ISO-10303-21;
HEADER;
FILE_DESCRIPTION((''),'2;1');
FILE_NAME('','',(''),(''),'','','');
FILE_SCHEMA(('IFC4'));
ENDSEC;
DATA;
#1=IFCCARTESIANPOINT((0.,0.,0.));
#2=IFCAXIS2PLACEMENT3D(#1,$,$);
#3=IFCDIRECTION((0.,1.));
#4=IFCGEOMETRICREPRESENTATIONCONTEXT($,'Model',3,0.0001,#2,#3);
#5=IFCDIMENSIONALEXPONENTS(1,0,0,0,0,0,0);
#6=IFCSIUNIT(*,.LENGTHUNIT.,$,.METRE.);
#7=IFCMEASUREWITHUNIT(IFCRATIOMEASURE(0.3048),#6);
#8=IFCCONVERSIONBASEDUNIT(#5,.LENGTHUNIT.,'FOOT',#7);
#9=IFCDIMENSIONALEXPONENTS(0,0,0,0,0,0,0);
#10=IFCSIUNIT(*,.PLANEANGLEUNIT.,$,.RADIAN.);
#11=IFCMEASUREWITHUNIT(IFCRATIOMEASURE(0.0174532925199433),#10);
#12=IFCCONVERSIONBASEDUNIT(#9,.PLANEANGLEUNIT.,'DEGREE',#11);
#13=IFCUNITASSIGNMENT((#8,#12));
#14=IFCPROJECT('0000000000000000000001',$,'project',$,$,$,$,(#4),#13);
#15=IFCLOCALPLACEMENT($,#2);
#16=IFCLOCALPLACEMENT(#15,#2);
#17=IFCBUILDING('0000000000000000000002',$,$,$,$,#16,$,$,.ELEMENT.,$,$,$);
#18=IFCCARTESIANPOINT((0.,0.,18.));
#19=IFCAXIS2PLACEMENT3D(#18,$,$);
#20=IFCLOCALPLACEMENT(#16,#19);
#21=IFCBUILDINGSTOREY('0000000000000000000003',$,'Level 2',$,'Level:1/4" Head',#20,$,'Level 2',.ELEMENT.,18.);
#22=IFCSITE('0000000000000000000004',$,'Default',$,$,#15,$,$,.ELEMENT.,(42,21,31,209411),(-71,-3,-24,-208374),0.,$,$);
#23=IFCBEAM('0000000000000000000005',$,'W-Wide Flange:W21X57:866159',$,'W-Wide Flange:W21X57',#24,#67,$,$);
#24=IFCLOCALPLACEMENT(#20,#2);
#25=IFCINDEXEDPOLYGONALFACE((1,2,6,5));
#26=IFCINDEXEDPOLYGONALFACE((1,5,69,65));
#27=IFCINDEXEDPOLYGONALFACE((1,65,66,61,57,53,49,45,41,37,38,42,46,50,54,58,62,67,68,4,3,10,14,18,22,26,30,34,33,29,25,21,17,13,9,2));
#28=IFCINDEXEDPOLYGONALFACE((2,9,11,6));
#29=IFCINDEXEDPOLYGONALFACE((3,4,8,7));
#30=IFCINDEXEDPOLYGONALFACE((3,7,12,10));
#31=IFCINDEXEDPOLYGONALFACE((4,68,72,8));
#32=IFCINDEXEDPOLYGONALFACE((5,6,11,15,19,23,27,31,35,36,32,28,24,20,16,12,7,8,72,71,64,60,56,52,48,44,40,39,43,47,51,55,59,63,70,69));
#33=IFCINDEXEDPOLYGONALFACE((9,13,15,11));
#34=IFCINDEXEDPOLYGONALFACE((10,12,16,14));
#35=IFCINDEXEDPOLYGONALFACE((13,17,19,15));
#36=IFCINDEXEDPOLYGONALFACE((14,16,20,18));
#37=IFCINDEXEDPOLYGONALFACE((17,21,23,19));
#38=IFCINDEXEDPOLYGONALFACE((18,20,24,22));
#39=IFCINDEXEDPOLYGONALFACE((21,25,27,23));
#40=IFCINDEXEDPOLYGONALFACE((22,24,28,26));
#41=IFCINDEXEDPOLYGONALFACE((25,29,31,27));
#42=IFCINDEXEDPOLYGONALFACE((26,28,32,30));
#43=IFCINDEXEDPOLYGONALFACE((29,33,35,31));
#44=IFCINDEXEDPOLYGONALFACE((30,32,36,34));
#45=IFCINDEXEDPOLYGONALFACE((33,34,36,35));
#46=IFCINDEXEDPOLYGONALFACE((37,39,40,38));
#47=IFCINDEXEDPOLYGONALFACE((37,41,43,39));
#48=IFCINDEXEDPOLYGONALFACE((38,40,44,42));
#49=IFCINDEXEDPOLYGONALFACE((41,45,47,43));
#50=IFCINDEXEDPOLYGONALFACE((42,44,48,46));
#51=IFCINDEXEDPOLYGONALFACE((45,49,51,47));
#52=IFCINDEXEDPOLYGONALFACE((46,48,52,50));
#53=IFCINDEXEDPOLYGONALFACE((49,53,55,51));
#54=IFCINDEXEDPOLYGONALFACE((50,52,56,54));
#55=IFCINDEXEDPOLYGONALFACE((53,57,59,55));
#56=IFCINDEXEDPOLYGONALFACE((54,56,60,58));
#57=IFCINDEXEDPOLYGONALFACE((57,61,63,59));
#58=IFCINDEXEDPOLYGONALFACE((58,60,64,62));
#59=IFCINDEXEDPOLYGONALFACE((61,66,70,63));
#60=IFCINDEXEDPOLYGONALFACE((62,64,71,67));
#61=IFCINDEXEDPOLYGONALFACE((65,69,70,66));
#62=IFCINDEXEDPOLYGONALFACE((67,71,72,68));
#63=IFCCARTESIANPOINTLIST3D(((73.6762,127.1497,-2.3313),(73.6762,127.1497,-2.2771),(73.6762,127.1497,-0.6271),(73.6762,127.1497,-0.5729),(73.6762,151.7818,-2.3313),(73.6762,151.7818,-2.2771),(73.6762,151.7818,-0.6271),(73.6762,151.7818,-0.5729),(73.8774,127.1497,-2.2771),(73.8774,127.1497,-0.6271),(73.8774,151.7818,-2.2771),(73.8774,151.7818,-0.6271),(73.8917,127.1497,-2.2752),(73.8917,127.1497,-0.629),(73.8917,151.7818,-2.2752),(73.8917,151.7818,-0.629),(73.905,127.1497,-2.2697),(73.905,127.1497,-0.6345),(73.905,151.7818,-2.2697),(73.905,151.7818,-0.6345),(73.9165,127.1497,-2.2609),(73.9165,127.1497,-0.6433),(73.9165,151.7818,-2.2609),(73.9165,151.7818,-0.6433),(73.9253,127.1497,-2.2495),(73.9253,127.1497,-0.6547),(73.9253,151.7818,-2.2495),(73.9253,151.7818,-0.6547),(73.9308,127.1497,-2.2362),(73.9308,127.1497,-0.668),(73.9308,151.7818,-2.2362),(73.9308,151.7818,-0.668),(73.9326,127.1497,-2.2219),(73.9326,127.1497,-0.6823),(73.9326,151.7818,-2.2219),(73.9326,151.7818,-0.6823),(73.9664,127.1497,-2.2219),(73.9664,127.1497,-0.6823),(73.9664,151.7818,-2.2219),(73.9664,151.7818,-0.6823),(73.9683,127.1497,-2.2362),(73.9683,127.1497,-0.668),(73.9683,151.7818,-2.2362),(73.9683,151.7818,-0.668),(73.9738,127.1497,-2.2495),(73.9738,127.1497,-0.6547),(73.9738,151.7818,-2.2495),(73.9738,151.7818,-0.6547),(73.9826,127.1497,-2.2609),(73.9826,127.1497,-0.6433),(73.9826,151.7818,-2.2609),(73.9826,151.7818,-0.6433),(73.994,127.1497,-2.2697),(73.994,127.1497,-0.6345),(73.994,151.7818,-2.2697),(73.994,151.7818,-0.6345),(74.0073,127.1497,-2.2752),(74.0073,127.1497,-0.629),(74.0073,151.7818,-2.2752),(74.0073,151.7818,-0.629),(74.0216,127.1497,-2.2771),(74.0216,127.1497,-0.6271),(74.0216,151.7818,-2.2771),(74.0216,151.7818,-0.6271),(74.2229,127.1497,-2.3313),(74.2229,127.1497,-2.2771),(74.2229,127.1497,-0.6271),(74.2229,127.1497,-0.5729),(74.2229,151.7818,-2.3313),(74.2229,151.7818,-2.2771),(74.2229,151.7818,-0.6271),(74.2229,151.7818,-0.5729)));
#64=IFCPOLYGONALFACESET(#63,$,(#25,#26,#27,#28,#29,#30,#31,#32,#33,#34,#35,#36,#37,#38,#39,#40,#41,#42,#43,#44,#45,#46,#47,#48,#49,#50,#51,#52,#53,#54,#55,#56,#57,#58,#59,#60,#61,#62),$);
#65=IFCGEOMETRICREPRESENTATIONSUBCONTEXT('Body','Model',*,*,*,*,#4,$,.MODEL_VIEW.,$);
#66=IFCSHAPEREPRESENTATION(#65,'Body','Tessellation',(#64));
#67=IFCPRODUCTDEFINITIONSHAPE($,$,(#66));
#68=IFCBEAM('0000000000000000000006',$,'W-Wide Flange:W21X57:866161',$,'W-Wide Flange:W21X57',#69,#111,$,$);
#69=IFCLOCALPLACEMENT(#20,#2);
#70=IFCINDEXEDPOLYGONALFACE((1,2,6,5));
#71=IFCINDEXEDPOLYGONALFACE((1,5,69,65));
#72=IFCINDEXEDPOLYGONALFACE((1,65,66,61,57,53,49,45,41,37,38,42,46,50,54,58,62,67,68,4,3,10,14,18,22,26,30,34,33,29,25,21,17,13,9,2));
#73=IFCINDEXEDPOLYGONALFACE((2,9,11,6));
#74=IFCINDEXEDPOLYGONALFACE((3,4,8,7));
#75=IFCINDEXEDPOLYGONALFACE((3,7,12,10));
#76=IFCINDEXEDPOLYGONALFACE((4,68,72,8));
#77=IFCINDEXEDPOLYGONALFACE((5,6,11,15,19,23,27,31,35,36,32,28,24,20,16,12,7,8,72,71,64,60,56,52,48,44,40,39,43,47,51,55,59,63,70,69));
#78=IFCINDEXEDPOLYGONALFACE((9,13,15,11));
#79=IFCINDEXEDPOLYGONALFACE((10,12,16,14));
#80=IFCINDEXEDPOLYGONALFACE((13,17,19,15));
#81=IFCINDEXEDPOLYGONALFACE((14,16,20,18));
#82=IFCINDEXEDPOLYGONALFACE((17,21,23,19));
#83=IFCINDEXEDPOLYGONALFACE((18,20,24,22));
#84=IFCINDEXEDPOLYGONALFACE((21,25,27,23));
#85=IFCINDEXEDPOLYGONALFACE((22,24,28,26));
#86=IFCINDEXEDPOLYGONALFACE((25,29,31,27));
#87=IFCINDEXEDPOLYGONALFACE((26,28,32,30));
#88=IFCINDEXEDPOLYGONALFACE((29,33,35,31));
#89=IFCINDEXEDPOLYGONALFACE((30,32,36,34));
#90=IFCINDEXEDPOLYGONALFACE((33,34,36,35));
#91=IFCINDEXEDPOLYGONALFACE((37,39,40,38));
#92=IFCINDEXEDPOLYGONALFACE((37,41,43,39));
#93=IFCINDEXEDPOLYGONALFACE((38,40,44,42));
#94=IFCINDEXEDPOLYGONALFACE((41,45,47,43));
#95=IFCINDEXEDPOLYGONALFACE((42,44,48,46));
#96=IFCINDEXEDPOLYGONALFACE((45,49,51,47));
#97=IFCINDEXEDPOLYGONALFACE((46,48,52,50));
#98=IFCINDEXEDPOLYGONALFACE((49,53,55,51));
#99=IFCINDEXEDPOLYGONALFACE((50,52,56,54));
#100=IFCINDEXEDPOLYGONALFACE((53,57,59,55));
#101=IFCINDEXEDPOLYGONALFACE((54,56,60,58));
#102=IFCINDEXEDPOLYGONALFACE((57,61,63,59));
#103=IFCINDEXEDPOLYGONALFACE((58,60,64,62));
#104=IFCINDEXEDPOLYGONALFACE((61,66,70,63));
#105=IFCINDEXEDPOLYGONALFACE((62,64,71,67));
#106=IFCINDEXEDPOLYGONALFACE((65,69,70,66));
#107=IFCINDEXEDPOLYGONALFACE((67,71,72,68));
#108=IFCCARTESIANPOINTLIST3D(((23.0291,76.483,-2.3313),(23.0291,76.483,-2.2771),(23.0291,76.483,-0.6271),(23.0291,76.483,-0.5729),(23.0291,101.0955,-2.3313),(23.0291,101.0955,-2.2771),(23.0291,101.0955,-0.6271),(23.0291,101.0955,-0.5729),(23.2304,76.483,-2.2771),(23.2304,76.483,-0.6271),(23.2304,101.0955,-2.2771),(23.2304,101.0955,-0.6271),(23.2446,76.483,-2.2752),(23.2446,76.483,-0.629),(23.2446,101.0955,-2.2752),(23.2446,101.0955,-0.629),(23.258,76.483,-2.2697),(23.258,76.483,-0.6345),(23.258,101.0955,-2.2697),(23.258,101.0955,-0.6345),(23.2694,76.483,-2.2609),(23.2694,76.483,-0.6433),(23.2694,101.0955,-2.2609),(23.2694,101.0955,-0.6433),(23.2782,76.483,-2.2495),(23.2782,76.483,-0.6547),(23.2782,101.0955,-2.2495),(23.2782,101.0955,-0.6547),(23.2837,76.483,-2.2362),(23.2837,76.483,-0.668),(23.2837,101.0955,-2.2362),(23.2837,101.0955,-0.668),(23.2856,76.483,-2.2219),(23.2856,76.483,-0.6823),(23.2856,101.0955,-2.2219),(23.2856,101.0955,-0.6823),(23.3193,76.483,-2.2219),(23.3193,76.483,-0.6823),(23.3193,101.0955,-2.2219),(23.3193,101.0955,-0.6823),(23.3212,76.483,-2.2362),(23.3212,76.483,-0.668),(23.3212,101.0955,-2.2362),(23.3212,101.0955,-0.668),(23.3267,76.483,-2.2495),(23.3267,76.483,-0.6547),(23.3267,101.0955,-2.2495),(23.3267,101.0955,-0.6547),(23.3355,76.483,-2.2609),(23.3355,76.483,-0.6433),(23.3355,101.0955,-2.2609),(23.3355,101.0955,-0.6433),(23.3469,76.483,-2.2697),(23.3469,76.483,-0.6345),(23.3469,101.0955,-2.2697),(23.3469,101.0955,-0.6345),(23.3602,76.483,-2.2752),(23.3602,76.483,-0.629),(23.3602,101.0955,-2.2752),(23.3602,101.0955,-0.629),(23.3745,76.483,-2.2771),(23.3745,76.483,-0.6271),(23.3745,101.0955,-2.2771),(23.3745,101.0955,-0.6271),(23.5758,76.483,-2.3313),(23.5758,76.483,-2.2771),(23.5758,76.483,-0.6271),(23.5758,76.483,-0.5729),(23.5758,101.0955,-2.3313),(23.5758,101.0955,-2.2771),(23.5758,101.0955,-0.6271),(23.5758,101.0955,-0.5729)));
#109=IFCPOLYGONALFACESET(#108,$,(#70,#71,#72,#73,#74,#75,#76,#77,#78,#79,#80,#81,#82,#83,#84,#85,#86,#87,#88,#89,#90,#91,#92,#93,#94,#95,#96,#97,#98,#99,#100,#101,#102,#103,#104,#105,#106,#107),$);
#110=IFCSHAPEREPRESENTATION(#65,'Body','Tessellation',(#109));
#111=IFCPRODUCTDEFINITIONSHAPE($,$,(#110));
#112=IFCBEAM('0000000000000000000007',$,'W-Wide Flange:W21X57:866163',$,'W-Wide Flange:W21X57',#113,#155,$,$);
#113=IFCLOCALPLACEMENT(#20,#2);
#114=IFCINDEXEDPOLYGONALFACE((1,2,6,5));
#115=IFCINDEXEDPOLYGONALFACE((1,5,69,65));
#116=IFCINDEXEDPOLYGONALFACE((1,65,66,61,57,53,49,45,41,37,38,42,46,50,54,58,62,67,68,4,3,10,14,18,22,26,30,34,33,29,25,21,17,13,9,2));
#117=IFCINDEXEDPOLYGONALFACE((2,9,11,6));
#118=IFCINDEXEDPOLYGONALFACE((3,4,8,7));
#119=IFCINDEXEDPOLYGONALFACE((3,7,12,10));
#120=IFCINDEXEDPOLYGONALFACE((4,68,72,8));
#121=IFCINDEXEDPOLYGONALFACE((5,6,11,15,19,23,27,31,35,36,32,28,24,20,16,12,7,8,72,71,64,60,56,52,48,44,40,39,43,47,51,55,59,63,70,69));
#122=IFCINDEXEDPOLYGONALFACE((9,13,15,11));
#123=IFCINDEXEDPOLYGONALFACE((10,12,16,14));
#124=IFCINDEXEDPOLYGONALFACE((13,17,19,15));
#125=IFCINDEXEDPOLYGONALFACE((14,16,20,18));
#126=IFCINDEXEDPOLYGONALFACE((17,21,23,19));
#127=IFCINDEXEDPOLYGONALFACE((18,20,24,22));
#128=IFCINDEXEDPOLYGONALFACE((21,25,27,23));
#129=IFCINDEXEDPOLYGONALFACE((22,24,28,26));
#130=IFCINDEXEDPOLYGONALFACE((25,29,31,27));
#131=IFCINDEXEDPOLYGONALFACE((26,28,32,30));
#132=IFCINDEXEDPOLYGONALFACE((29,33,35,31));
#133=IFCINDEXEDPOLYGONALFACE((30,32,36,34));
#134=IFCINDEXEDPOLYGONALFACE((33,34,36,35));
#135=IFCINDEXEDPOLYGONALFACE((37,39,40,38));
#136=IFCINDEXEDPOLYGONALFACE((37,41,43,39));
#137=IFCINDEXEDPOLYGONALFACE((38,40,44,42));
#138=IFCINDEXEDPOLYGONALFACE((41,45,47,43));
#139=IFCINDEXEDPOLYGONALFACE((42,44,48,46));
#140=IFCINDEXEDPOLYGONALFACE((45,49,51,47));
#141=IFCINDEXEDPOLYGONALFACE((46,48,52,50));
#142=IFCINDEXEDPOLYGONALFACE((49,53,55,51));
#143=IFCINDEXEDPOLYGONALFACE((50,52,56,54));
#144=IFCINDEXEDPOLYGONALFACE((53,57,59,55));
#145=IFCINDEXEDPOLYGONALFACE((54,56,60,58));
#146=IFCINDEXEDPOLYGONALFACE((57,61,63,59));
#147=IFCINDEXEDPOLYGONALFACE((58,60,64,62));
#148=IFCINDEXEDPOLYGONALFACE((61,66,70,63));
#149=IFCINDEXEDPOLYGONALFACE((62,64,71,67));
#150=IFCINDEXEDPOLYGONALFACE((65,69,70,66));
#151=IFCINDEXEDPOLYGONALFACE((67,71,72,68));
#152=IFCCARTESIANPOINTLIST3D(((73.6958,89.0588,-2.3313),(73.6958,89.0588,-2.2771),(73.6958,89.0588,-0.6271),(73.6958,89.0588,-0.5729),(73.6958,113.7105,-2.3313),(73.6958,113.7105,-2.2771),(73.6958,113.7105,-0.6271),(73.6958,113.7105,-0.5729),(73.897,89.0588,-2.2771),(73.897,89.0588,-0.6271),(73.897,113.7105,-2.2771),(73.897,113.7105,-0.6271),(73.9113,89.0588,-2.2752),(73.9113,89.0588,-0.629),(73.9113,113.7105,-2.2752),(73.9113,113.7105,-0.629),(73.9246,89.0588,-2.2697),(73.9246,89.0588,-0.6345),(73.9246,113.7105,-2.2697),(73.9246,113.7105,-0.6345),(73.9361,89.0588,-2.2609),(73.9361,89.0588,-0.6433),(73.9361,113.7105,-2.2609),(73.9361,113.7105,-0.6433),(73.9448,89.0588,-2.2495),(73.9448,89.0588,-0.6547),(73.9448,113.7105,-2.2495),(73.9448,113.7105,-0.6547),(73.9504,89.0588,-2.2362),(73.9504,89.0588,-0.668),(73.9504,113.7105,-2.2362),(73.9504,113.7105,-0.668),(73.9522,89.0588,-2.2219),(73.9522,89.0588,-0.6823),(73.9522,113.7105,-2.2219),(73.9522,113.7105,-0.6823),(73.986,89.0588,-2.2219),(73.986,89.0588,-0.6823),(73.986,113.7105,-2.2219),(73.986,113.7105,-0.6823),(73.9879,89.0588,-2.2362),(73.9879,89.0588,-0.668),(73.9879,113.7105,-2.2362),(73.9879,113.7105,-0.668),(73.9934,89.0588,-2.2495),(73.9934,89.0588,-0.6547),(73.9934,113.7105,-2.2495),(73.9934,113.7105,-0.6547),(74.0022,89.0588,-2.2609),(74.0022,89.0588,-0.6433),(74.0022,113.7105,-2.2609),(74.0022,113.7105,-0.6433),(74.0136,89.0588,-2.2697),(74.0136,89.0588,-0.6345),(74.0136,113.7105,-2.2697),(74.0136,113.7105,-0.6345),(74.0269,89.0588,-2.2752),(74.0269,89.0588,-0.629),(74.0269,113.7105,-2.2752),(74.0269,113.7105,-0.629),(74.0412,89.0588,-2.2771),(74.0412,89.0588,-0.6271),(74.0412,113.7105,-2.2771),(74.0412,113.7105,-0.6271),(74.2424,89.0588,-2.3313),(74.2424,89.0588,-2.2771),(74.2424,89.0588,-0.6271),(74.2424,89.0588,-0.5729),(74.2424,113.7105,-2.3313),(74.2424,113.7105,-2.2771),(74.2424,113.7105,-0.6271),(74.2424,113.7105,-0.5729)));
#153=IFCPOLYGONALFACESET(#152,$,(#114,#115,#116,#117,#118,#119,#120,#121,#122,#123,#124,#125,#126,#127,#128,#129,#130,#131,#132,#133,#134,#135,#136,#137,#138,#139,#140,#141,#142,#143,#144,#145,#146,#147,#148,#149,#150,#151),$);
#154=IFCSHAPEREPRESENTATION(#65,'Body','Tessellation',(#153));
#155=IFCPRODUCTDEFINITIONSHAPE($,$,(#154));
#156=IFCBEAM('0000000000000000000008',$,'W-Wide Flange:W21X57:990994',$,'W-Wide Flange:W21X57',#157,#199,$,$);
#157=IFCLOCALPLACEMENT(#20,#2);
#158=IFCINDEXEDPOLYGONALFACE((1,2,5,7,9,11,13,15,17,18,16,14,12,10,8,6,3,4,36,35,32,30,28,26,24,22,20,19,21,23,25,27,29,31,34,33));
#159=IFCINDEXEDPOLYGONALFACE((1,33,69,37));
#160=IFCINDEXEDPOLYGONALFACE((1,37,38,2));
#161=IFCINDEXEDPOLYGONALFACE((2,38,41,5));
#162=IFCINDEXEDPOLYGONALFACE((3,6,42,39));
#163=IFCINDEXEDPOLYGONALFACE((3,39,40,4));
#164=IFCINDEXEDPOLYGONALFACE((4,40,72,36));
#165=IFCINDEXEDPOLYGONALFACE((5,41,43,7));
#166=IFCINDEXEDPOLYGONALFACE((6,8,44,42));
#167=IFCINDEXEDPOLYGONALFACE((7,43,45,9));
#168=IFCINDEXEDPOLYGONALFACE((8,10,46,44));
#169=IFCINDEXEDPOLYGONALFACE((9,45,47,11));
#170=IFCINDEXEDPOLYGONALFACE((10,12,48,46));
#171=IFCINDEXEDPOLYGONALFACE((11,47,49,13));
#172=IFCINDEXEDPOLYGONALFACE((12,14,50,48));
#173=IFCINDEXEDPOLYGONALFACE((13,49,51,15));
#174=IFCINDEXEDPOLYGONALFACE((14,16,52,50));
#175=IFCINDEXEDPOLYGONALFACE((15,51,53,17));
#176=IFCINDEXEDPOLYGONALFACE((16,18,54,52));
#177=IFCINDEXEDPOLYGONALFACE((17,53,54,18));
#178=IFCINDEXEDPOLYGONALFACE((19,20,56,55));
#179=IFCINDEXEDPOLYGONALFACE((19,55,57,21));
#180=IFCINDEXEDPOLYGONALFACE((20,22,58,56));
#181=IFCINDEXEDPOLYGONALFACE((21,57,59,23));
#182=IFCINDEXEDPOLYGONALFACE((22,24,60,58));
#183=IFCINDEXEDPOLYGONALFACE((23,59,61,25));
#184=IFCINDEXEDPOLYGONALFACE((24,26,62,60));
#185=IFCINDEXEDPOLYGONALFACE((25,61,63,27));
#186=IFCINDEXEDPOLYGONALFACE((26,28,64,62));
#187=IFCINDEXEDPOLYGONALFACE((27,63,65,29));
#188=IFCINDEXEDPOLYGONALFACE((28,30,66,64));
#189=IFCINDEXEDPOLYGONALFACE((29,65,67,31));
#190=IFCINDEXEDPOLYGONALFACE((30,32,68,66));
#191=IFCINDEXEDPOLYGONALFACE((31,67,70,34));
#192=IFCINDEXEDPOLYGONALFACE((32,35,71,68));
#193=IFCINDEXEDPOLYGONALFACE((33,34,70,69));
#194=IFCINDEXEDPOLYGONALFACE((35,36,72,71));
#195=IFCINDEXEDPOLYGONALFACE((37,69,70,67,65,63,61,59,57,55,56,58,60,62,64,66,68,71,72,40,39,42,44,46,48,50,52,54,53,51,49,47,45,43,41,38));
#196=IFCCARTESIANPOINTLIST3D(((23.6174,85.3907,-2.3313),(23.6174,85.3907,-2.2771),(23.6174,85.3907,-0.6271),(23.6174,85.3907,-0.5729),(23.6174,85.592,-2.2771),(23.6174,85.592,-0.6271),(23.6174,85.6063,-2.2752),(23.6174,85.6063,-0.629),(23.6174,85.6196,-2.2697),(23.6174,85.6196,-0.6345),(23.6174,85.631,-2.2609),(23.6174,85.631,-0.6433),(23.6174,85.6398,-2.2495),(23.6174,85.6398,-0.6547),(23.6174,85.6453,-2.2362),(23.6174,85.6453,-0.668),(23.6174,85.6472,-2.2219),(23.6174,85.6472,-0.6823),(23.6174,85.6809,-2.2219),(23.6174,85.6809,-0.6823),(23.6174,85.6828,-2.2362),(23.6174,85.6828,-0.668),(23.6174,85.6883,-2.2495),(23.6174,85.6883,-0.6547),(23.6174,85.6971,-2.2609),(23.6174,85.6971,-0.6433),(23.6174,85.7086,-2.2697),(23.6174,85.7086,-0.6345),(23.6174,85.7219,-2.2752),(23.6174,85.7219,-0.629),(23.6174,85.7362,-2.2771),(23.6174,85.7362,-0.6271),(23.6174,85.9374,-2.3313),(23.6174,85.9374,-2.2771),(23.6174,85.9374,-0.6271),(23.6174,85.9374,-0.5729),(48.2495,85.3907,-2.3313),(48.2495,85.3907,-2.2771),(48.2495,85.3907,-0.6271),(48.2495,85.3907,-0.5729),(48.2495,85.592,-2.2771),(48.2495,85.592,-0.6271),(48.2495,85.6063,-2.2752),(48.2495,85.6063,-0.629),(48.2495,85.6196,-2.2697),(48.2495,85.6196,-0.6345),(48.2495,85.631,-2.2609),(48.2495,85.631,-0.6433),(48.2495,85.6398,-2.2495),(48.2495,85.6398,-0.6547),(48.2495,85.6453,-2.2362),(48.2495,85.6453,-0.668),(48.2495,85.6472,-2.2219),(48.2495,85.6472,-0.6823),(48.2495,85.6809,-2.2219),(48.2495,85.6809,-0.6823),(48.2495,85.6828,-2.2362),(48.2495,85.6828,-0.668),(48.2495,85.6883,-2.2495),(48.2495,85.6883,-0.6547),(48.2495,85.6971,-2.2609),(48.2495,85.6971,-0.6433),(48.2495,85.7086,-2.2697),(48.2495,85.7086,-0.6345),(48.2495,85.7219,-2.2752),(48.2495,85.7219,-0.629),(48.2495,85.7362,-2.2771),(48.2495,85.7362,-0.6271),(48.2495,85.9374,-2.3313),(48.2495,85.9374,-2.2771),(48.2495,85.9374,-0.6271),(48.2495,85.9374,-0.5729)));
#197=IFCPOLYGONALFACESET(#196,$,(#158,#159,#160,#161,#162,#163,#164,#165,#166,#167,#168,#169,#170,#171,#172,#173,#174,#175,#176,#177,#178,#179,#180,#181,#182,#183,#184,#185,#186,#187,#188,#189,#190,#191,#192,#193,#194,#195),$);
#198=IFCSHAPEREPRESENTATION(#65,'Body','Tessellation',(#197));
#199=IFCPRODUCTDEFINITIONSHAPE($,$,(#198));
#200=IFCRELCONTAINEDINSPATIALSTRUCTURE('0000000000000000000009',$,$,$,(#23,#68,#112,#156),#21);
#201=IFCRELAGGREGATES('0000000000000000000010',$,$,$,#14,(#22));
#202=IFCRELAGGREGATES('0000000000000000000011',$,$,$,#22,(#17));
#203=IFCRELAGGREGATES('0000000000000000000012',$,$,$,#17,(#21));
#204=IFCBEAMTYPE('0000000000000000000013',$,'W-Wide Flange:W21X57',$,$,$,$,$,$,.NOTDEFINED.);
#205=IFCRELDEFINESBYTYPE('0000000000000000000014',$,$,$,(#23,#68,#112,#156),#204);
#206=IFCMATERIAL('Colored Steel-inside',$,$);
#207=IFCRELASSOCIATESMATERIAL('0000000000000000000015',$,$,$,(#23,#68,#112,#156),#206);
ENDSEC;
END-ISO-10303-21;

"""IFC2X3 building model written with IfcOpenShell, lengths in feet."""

from ifc_helpers import new_model, entity, si_unit, converted_unit, direction, frame, frame_2d, origin, place, context, subcontext, project, spatial, i_section, extrude, material, type_object, element, save


model = new_model("IFC2X3")

# Units and contexts
model_context = context("Model", 3, precision=0.0001, world=origin(), true_north=direction((0.0, 1.0)))
body_context = subcontext(model_context, "Body", "Model", "MODEL_VIEW")
ifc_project = project(units=[converted_unit("LENGTHUNIT", "FOOT", entity("IfcRatioMeasure", 0.3048), si_unit("LENGTHUNIT", "METRE"), dimensions=[1, 0, 0, 0, 0, 0, 0]), converted_unit("PLANEANGLEUNIT", "DEGREE", entity("IfcRatioMeasure", 0.0174532925199433), si_unit("PLANEANGLEUNIT", "RADIAN"), dimensions=[0, 0, 0, 0, 0, 0, 0])], contexts=[model_context])

# Site, building, storey
site_placement = place(None, origin())
site = spatial("IfcSite", under=ifc_project, at=site_placement, Name="Default", CompositionType="ELEMENT", RefLatitude=(42, 21, 31, 209411), RefLongitude=(-71, -3, -24, -208374), RefElevation=0.0)
building_placement = place(site_placement, origin())
building = spatial("IfcBuilding", under=site, at=building_placement, CompositionType="ELEMENT")
storey_placement = place(building_placement, frame((0.0, 0.0, 18.0)))
storey = spatial("IfcBuildingStorey", under=building, at=storey_placement, Name="Level 2", ObjectType="Level:1/4\" Head", LongName="Level 2", CompositionType="ELEMENT", Elevation=18.0)

# Shared definitions
ifc_material_1 = material(Name="Colored Steel-inside")

# Beams
beam_type_1 = type_object("IfcBeamType", Name="W-Wide Flange:W21X57", PredefinedType="NOTDEFINED")
beam_1_placement = place(storey_placement, frame((73.9495, 126.7634, 0.0), z_axis=(0.0, 0.0, 1.0), x_axis=(0.0, 1.0, 0.0)))
element("IfcBeam", 1, at=beam_1_placement, inside=storey, type_object=beam_type_1, material=ifc_material_1, Name="W-Wide Flange:W21X57:866159", ObjectType="W-Wide Flange:W21X57", context=body_context, shape_type="SweptSolid", body=[
    extrude(i_section(OverallWidth=0.5467, OverallDepth=1.7583, WebThickness=0.0337, FlangeThickness=0.0542, FilletRadius=0.0552, at=frame_2d((0.0, 0.0), x_axis=(0.0, 1.0))), frame((0.3862, 0.0, -1.4521), z_axis=(1.0, 0.0, 0.0), x_axis=(0.0, 0.0, -1.0)), (0.0, 0.0, 1.0), 24.6321),
])
beam_2_placement = place(storey_placement, frame((23.3024, 101.4105, 0.0), z_axis=(0.0, 0.0, 1.0), x_axis=(0.0, -1.0, 0.0)))
element("IfcBeam", 2, at=beam_2_placement, inside=storey, type_object=beam_type_1, material=ifc_material_1, Name="W-Wide Flange:W21X57:866161", ObjectType="W-Wide Flange:W21X57", context=body_context, shape_type="SweptSolid", body=[
    extrude(i_section(OverallWidth=0.5467, OverallDepth=1.7583, WebThickness=0.0338, FlangeThickness=0.0542, FilletRadius=0.0552, at=frame_2d((0.0, 0.0), x_axis=(0.0, 1.0))), frame((0.315, 0.0, -1.4521), z_axis=(1.0, 0.0, 0.0), x_axis=(0.0, 0.0, -1.0)), (0.0, 0.0, 1.0), 24.6125),
])
beam_3_placement = place(storey_placement, frame((73.9691, 114.0968, 0.0), z_axis=(0.0, 0.0, 1.0), x_axis=(0.0, -1.0, 0.0)))
element("IfcBeam", 3, at=beam_3_placement, inside=storey, type_object=beam_type_1, material=ifc_material_1, Name="W-Wide Flange:W21X57:866163", ObjectType="W-Wide Flange:W21X57", context=body_context, shape_type="SweptSolid", body=[
    extrude(i_section(OverallWidth=0.5467, OverallDepth=1.7583, WebThickness=0.0337, FlangeThickness=0.0542, FilletRadius=0.0552, at=frame_2d((0.0, 0.0), x_axis=(0.0, 1.0))), frame((0.3863, 0.0, -1.4521), z_axis=(1.0, 0.0, 0.0), x_axis=(0.0, 0.0, -1.0)), (0.0, 0.0, 1.0), 24.6517),
])
beam_4_placement = place(storey_placement, frame((48.6358, 85.6641, 0.0), z_axis=(0.0, 0.0, 1.0), x_axis=(-1.0, 0.0, 0.0)))
element("IfcBeam", 4, at=beam_4_placement, inside=storey, type_object=beam_type_1, material=ifc_material_1, Name="W-Wide Flange:W21X57:990994", ObjectType="W-Wide Flange:W21X57", context=body_context, shape_type="SweptSolid", body=[
    extrude(i_section(OverallWidth=0.5467, OverallDepth=1.7583, WebThickness=0.0337, FlangeThickness=0.0542, FilletRadius=0.0552, at=frame_2d((0.0, 0.0), x_axis=(0.0, 1.0))), frame((0.3863, 0.0, -1.4521), z_axis=(1.0, 0.0, 0.0), x_axis=(0.0, 0.0, -1.0)), (0.0, 0.0, 1.0), 24.6321),
])

save(model, "model.ifc")
